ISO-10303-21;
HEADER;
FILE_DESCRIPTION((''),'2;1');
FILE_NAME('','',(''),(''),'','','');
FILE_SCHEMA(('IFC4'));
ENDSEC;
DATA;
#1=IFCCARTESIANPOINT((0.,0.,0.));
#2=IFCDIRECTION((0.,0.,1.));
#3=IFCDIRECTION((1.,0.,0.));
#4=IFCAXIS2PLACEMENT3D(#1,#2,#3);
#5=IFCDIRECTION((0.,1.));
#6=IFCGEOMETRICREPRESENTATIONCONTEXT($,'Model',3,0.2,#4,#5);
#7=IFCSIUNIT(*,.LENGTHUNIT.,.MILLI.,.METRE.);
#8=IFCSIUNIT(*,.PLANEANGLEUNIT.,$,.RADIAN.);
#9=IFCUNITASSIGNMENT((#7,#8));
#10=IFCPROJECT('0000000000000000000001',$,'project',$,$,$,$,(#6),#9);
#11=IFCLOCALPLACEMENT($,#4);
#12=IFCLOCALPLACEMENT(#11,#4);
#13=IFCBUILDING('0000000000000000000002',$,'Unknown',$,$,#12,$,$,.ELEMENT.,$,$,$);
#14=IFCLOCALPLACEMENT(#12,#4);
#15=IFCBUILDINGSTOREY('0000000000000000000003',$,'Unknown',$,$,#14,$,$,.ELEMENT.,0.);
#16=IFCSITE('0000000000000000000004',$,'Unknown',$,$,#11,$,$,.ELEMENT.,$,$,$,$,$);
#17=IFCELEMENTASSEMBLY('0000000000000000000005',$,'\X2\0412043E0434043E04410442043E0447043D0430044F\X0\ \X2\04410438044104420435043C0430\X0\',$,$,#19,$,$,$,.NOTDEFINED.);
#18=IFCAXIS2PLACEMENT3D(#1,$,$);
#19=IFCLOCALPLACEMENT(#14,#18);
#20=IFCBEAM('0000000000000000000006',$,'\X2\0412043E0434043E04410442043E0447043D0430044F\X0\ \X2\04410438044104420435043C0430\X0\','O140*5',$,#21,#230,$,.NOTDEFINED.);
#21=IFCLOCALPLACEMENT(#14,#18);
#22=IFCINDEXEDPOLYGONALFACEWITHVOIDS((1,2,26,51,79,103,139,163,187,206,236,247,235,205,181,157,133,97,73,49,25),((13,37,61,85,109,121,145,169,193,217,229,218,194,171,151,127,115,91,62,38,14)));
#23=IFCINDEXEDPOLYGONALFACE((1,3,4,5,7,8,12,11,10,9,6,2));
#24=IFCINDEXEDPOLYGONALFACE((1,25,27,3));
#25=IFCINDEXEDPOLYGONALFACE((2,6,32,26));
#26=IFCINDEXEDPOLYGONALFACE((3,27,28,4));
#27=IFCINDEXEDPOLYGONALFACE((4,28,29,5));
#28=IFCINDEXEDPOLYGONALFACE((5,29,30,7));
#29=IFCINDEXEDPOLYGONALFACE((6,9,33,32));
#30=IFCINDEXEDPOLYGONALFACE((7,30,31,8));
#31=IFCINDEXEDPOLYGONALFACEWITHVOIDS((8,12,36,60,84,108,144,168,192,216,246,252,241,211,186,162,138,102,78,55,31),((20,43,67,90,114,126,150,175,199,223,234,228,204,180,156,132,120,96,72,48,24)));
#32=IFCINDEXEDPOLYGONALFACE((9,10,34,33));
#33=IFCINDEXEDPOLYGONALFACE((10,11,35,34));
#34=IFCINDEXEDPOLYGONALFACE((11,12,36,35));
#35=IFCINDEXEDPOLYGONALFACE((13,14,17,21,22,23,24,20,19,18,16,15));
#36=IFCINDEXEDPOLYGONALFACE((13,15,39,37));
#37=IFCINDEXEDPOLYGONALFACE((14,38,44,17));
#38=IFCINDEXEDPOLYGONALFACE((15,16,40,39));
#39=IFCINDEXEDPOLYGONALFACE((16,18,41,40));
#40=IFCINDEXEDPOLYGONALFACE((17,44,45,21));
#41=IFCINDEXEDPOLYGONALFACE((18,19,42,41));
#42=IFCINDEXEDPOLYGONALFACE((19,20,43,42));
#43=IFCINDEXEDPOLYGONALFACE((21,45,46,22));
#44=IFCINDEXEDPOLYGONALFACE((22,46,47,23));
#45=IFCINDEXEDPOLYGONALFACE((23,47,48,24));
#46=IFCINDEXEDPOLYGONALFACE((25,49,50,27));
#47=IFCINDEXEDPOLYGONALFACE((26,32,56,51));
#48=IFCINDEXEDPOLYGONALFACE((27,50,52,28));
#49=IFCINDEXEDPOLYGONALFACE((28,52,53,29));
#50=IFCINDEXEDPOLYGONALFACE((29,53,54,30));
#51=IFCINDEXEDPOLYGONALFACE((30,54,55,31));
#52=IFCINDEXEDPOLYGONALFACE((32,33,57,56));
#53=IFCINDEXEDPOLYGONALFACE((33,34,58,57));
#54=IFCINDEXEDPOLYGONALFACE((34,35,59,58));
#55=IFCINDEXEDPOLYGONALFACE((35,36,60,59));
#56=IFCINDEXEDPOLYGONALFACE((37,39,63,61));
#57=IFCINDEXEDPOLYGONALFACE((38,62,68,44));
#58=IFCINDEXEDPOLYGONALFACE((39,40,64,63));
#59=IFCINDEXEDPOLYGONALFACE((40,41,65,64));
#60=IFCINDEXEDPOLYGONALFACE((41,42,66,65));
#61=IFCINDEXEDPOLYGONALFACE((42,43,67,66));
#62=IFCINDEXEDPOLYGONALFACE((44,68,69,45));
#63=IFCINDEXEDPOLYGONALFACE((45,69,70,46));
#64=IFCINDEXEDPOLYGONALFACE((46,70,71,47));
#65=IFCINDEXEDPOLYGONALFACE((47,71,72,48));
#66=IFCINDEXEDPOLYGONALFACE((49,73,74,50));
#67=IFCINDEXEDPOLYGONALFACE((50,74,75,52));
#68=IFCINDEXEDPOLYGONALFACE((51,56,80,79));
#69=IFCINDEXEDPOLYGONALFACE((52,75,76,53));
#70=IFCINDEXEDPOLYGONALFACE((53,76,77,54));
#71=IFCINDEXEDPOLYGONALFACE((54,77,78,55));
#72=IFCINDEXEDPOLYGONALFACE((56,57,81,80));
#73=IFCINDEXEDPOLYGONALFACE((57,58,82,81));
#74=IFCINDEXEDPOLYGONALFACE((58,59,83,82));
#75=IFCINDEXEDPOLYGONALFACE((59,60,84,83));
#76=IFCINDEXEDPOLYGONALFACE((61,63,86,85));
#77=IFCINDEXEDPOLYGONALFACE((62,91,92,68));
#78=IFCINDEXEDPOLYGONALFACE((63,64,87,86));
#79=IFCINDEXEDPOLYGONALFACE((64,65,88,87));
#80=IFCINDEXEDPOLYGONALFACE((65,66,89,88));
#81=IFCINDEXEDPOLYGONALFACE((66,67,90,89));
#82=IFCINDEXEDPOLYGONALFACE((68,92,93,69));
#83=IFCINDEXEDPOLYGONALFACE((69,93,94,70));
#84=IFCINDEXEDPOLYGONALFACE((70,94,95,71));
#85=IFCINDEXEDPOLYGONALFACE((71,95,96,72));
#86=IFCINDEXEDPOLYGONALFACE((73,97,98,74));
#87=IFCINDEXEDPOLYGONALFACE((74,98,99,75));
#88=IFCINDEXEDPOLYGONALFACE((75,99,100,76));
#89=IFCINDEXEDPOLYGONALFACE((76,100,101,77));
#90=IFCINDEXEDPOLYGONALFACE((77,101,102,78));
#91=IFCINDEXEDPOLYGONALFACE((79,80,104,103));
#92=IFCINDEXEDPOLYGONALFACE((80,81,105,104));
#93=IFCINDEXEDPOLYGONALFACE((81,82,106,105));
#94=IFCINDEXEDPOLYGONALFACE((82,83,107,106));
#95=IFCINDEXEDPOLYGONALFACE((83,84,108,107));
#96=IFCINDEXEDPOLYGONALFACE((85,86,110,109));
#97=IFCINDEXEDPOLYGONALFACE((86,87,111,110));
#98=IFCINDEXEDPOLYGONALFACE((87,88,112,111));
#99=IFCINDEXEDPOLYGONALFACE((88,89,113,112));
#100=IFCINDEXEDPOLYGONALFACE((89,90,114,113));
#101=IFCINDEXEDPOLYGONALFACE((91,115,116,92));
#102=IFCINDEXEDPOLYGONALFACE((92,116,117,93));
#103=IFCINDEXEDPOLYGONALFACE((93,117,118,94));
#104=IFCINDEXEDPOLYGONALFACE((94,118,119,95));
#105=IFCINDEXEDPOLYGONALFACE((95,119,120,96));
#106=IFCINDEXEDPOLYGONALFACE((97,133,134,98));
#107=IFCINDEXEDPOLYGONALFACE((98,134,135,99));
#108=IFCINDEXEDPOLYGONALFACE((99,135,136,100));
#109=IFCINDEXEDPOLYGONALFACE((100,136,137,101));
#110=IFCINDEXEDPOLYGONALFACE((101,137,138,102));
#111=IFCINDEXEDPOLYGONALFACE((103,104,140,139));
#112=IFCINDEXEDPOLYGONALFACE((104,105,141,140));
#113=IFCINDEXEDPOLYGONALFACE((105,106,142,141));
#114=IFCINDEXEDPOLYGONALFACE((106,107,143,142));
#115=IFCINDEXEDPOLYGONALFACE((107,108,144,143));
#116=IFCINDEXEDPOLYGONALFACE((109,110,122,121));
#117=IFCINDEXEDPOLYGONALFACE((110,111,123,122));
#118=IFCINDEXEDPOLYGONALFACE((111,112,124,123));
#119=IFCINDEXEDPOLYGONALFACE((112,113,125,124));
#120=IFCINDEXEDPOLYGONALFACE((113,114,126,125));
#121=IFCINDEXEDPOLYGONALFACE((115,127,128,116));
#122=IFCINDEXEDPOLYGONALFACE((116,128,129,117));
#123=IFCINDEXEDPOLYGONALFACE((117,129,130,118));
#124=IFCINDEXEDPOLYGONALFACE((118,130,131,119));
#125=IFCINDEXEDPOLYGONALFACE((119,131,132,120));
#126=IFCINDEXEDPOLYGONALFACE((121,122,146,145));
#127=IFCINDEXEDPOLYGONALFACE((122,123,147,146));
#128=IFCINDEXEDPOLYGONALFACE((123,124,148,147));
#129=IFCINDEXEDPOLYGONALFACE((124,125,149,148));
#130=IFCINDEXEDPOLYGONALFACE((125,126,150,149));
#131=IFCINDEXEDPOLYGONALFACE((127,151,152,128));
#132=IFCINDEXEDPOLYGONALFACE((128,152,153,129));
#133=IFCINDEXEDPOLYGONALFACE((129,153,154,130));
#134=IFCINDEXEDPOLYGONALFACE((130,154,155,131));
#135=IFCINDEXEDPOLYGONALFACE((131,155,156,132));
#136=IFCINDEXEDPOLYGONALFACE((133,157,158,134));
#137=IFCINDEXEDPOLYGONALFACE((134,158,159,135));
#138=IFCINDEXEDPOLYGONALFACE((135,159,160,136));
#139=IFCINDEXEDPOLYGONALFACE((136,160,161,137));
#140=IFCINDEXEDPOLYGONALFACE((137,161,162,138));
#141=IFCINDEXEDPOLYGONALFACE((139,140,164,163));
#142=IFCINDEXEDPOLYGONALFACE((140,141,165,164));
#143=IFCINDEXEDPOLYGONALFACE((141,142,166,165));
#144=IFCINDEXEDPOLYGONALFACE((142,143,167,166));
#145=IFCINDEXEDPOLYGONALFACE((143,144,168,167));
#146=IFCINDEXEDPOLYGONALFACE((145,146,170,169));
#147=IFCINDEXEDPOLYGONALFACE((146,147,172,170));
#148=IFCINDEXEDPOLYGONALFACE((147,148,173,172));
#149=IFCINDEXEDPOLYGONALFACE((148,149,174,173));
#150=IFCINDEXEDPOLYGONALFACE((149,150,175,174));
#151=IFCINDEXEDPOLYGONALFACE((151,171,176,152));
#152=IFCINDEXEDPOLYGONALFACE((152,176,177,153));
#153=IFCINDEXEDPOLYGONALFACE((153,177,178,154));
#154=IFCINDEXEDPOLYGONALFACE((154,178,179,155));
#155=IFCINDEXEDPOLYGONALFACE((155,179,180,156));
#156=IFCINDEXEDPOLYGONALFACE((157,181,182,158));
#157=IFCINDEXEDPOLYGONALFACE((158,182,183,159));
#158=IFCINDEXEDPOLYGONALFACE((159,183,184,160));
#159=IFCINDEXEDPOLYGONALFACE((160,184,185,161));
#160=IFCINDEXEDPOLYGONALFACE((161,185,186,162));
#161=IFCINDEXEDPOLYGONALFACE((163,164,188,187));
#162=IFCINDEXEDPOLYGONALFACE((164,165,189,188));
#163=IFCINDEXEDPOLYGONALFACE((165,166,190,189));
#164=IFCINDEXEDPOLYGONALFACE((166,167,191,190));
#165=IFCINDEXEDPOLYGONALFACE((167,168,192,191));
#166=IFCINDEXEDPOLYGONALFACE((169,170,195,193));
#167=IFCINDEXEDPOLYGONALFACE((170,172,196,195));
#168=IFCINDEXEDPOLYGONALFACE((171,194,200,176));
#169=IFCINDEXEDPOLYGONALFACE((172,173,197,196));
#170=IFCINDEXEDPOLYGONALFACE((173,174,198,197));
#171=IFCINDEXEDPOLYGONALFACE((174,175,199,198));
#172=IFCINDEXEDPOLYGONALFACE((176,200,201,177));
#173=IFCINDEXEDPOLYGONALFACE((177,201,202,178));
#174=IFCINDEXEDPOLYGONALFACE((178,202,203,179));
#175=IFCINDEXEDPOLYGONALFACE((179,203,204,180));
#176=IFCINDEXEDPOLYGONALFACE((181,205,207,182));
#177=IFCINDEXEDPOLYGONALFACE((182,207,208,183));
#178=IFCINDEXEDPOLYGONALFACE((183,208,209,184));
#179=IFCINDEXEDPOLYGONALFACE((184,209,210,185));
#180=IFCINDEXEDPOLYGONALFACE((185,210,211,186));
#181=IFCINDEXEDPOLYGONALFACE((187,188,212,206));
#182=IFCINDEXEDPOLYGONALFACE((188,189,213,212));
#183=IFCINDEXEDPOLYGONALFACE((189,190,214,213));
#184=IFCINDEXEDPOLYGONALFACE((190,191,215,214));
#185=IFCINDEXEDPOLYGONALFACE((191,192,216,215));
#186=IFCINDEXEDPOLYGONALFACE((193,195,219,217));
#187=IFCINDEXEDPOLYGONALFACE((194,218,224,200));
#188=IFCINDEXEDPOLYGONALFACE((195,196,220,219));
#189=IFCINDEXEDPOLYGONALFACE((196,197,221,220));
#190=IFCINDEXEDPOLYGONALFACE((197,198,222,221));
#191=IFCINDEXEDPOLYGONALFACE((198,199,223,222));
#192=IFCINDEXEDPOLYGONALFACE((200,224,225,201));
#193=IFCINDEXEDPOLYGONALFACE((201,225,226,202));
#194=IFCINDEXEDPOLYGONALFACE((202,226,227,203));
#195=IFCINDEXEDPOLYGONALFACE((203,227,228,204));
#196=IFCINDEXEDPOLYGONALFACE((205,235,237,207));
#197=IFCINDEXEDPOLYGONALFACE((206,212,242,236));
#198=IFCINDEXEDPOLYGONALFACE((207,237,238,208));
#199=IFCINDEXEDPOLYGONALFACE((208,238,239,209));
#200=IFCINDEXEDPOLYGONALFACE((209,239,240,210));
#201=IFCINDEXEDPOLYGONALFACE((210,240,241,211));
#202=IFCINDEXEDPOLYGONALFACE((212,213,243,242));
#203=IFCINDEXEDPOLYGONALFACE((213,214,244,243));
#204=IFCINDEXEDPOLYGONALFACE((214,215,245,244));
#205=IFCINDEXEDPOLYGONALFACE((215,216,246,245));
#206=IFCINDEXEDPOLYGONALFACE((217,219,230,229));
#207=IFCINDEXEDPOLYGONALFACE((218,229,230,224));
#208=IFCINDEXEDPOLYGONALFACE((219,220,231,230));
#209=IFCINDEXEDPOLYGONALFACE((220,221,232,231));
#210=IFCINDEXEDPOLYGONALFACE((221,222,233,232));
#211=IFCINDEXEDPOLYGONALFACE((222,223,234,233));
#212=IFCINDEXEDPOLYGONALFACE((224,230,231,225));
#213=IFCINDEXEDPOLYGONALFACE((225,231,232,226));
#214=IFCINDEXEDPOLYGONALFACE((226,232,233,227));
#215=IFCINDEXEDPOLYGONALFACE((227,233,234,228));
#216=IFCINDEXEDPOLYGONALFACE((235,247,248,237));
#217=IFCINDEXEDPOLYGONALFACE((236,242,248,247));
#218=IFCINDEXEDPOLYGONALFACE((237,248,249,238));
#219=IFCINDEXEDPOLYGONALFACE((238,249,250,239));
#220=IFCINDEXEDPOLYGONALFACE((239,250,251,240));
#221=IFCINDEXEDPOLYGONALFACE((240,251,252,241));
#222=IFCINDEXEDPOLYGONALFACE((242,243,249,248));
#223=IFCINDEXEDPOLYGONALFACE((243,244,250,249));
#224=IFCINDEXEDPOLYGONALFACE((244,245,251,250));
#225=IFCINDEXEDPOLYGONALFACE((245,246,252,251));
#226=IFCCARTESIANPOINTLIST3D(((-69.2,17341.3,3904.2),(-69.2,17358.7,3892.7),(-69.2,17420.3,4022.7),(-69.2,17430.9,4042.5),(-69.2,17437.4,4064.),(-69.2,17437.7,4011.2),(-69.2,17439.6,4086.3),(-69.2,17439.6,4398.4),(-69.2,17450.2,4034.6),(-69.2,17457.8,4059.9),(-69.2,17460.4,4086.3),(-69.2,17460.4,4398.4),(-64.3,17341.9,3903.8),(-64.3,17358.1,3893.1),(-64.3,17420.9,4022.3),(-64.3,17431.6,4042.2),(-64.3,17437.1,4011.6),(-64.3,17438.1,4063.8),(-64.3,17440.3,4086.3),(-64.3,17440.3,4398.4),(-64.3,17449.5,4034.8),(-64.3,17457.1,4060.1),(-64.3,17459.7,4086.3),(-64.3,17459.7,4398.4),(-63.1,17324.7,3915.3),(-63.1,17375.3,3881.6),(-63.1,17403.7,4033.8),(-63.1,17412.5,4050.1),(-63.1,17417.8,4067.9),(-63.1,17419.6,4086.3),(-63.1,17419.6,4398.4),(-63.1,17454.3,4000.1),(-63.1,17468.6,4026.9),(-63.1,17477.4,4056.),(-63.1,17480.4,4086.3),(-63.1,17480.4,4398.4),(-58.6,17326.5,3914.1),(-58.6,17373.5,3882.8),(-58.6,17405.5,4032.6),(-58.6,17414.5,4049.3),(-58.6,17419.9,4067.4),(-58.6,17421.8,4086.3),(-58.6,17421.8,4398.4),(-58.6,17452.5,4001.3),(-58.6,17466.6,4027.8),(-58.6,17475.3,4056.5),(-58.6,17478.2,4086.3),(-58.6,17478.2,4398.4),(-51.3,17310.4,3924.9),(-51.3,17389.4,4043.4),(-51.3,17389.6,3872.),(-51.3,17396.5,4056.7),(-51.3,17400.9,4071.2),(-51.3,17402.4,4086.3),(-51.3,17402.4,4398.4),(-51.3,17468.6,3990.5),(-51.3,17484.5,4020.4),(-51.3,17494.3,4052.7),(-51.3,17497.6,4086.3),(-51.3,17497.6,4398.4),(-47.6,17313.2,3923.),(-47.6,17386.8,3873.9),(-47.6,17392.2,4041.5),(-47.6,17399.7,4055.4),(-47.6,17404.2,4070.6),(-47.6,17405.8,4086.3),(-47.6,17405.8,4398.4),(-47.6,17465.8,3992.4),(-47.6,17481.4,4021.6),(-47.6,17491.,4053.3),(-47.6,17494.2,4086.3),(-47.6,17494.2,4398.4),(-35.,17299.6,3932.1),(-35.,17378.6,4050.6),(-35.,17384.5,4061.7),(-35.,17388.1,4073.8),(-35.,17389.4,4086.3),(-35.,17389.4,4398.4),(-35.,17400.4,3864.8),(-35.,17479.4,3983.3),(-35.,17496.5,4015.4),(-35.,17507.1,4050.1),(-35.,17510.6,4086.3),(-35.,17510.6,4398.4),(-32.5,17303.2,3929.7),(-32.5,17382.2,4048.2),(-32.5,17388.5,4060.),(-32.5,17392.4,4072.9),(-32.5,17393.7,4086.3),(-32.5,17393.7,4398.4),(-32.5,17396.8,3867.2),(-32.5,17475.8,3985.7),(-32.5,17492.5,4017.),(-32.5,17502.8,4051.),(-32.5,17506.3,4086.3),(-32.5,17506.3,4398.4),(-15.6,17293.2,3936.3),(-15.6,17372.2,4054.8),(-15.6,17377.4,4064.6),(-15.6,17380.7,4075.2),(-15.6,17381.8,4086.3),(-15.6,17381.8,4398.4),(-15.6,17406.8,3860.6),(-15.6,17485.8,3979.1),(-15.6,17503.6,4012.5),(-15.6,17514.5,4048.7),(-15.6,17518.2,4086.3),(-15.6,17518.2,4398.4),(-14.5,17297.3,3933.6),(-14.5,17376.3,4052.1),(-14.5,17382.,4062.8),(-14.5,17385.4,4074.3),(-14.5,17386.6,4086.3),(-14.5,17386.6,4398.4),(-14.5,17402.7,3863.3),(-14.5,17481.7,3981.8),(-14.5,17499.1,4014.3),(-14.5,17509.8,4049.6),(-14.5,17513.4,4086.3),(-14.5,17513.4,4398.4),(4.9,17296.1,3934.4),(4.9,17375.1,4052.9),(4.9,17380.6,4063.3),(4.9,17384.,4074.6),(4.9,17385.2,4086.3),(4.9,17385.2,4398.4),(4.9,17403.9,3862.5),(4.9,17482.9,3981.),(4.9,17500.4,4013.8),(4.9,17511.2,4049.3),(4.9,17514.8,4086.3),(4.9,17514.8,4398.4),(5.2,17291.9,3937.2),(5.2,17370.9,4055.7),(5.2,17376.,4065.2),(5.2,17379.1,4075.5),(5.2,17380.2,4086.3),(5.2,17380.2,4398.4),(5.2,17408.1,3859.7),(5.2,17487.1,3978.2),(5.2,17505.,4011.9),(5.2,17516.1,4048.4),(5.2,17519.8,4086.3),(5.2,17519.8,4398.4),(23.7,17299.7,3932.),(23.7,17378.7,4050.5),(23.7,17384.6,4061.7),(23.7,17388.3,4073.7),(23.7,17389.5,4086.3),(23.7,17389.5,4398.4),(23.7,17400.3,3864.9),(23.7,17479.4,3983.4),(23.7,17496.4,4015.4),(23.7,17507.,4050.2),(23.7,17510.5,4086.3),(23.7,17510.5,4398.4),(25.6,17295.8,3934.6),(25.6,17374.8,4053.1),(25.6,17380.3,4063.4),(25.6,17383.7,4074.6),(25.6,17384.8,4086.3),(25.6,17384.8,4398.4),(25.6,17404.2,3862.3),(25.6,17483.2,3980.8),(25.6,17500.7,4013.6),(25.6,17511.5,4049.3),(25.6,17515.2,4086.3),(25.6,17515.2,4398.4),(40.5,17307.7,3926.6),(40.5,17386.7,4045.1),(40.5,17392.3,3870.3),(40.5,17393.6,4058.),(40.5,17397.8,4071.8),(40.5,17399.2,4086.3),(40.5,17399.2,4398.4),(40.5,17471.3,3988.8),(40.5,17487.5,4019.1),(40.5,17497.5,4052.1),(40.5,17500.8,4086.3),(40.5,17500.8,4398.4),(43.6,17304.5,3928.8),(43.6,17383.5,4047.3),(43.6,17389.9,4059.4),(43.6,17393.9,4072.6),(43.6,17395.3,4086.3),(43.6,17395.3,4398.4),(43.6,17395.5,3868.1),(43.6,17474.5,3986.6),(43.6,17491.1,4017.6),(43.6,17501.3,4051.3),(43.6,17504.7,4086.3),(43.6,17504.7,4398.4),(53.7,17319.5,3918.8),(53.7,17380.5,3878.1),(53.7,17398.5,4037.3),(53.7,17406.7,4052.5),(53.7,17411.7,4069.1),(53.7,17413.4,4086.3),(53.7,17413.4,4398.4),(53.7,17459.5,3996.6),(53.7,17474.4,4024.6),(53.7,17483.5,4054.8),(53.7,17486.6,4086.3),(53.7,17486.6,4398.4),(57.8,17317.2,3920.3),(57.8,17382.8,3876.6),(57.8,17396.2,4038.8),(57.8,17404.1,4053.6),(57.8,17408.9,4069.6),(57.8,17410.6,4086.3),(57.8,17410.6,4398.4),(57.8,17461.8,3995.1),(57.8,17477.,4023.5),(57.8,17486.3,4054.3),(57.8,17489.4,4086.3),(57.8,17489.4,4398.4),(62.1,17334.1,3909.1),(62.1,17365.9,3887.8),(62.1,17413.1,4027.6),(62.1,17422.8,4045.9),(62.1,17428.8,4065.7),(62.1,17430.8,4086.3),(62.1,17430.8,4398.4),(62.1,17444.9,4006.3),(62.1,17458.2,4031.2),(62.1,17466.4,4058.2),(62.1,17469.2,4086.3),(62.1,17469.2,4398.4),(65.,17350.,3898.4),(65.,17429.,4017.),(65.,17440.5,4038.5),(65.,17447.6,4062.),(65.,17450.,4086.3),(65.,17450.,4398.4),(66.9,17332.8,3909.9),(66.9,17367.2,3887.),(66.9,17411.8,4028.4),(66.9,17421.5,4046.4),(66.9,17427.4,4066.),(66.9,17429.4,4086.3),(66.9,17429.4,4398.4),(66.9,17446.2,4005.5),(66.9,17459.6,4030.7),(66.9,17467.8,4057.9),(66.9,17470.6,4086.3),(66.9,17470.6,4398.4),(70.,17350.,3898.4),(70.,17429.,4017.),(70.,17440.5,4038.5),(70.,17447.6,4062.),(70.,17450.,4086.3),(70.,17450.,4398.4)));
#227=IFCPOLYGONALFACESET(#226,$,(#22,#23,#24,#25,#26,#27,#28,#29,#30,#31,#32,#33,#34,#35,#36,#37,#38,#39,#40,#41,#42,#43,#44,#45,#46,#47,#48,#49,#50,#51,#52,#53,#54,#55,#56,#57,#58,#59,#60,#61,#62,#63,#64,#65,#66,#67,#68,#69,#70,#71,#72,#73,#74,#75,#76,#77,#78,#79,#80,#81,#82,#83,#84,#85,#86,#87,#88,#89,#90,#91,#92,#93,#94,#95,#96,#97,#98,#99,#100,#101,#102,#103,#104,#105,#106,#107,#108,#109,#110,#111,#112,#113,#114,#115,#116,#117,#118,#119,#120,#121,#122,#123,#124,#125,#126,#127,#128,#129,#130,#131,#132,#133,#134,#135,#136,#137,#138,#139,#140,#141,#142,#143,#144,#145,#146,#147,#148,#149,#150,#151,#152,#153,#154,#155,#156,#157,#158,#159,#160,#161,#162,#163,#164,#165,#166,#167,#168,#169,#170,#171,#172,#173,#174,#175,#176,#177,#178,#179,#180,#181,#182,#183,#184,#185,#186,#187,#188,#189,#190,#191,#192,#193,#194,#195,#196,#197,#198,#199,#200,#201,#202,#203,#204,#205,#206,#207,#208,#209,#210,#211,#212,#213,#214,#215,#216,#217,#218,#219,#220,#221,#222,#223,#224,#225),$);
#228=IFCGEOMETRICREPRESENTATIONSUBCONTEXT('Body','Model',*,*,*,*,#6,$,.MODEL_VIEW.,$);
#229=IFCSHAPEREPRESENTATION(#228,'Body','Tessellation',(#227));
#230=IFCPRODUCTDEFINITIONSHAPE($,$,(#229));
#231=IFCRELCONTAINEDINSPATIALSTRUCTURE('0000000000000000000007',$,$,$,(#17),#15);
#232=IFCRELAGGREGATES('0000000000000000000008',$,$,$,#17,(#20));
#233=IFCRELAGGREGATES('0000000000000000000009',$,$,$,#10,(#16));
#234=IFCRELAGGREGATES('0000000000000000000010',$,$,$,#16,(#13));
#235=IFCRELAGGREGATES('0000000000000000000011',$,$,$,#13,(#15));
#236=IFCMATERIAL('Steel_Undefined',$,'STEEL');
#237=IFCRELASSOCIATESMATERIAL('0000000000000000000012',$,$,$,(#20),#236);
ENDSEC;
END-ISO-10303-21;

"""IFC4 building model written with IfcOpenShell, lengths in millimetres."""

from ifc_helpers import new_model, entity, si_unit, direction, frame, origin_with_axes, place, context, subcontext, project, spatial, material, element, aggregate, save


model = new_model("IFC4")

# Units and contexts
model_context = context("Model", 3, precision=0.2, world=origin_with_axes(), true_north=direction((0.0, 1.0)))
body_context = subcontext(model_context, "Body", "Model", "MODEL_VIEW")
ifc_project = project(units=[si_unit("LENGTHUNIT", "METRE", prefix="MILLI"), si_unit("PLANEANGLEUNIT", "RADIAN")], contexts=[model_context])

# Site, building, storey
site_placement = place(None, origin_with_axes())
site = spatial("IfcSite", under=ifc_project, at=site_placement, Name="Unknown", CompositionType="ELEMENT")
building_placement = place(site_placement, origin_with_axes())
building = spatial("IfcBuilding", under=site, at=building_placement, Name="Unknown", CompositionType="ELEMENT")
storey_placement = place(building_placement, origin_with_axes())
storey = spatial("IfcBuildingStorey", under=building, at=storey_placement, Name="Unknown", CompositionType="ELEMENT", Elevation=0.0)

# Element assembly, beam
ifc_material_1 = material(Name="Steel_Undefined", Category="STEEL")
assembly_1_placement = place(storey_placement, frame((0.0, 17450.0, 4398.4), z_axis=(1.0, 0.0, 0.0), x_axis=(0.0, 0.0, -1.0)))
assembly_1 = element("IfcElementAssembly", 1, at=assembly_1_placement, inside=storey, Name="Водосточная система", PredefinedType="NOTDEFINED")
beam_1_placement = place(assembly_1_placement, origin_with_axes())
beam_1 = element("IfcBeam", 2, at=beam_1_placement, material=ifc_material_1, Name="Водосточная система", Description="O140*5", PredefinedType="NOTDEFINED", context=body_context, shape_type="SolidModel", body=[
    entity("IfcSweptDiskSolid", entity("IfcIndexedPolyCurve", entity("IfcCartesianPointList3D", [[0.0, 0.0, 0.0], [312.2, 0.0, 0.0], [348.4, -5.4, 0.0], [381.5, -21.0, 0.0], [500.0, -100.0, 0.0]]), [entity("IfcLineIndex", [1, 2]), entity("IfcArcIndex", [2, 3, 4]), entity("IfcLineIndex", [4, 5])]), 70.0, 65.0),
])
aggregate(assembly_1, [beam_1])

save(model, "model.ifc")
